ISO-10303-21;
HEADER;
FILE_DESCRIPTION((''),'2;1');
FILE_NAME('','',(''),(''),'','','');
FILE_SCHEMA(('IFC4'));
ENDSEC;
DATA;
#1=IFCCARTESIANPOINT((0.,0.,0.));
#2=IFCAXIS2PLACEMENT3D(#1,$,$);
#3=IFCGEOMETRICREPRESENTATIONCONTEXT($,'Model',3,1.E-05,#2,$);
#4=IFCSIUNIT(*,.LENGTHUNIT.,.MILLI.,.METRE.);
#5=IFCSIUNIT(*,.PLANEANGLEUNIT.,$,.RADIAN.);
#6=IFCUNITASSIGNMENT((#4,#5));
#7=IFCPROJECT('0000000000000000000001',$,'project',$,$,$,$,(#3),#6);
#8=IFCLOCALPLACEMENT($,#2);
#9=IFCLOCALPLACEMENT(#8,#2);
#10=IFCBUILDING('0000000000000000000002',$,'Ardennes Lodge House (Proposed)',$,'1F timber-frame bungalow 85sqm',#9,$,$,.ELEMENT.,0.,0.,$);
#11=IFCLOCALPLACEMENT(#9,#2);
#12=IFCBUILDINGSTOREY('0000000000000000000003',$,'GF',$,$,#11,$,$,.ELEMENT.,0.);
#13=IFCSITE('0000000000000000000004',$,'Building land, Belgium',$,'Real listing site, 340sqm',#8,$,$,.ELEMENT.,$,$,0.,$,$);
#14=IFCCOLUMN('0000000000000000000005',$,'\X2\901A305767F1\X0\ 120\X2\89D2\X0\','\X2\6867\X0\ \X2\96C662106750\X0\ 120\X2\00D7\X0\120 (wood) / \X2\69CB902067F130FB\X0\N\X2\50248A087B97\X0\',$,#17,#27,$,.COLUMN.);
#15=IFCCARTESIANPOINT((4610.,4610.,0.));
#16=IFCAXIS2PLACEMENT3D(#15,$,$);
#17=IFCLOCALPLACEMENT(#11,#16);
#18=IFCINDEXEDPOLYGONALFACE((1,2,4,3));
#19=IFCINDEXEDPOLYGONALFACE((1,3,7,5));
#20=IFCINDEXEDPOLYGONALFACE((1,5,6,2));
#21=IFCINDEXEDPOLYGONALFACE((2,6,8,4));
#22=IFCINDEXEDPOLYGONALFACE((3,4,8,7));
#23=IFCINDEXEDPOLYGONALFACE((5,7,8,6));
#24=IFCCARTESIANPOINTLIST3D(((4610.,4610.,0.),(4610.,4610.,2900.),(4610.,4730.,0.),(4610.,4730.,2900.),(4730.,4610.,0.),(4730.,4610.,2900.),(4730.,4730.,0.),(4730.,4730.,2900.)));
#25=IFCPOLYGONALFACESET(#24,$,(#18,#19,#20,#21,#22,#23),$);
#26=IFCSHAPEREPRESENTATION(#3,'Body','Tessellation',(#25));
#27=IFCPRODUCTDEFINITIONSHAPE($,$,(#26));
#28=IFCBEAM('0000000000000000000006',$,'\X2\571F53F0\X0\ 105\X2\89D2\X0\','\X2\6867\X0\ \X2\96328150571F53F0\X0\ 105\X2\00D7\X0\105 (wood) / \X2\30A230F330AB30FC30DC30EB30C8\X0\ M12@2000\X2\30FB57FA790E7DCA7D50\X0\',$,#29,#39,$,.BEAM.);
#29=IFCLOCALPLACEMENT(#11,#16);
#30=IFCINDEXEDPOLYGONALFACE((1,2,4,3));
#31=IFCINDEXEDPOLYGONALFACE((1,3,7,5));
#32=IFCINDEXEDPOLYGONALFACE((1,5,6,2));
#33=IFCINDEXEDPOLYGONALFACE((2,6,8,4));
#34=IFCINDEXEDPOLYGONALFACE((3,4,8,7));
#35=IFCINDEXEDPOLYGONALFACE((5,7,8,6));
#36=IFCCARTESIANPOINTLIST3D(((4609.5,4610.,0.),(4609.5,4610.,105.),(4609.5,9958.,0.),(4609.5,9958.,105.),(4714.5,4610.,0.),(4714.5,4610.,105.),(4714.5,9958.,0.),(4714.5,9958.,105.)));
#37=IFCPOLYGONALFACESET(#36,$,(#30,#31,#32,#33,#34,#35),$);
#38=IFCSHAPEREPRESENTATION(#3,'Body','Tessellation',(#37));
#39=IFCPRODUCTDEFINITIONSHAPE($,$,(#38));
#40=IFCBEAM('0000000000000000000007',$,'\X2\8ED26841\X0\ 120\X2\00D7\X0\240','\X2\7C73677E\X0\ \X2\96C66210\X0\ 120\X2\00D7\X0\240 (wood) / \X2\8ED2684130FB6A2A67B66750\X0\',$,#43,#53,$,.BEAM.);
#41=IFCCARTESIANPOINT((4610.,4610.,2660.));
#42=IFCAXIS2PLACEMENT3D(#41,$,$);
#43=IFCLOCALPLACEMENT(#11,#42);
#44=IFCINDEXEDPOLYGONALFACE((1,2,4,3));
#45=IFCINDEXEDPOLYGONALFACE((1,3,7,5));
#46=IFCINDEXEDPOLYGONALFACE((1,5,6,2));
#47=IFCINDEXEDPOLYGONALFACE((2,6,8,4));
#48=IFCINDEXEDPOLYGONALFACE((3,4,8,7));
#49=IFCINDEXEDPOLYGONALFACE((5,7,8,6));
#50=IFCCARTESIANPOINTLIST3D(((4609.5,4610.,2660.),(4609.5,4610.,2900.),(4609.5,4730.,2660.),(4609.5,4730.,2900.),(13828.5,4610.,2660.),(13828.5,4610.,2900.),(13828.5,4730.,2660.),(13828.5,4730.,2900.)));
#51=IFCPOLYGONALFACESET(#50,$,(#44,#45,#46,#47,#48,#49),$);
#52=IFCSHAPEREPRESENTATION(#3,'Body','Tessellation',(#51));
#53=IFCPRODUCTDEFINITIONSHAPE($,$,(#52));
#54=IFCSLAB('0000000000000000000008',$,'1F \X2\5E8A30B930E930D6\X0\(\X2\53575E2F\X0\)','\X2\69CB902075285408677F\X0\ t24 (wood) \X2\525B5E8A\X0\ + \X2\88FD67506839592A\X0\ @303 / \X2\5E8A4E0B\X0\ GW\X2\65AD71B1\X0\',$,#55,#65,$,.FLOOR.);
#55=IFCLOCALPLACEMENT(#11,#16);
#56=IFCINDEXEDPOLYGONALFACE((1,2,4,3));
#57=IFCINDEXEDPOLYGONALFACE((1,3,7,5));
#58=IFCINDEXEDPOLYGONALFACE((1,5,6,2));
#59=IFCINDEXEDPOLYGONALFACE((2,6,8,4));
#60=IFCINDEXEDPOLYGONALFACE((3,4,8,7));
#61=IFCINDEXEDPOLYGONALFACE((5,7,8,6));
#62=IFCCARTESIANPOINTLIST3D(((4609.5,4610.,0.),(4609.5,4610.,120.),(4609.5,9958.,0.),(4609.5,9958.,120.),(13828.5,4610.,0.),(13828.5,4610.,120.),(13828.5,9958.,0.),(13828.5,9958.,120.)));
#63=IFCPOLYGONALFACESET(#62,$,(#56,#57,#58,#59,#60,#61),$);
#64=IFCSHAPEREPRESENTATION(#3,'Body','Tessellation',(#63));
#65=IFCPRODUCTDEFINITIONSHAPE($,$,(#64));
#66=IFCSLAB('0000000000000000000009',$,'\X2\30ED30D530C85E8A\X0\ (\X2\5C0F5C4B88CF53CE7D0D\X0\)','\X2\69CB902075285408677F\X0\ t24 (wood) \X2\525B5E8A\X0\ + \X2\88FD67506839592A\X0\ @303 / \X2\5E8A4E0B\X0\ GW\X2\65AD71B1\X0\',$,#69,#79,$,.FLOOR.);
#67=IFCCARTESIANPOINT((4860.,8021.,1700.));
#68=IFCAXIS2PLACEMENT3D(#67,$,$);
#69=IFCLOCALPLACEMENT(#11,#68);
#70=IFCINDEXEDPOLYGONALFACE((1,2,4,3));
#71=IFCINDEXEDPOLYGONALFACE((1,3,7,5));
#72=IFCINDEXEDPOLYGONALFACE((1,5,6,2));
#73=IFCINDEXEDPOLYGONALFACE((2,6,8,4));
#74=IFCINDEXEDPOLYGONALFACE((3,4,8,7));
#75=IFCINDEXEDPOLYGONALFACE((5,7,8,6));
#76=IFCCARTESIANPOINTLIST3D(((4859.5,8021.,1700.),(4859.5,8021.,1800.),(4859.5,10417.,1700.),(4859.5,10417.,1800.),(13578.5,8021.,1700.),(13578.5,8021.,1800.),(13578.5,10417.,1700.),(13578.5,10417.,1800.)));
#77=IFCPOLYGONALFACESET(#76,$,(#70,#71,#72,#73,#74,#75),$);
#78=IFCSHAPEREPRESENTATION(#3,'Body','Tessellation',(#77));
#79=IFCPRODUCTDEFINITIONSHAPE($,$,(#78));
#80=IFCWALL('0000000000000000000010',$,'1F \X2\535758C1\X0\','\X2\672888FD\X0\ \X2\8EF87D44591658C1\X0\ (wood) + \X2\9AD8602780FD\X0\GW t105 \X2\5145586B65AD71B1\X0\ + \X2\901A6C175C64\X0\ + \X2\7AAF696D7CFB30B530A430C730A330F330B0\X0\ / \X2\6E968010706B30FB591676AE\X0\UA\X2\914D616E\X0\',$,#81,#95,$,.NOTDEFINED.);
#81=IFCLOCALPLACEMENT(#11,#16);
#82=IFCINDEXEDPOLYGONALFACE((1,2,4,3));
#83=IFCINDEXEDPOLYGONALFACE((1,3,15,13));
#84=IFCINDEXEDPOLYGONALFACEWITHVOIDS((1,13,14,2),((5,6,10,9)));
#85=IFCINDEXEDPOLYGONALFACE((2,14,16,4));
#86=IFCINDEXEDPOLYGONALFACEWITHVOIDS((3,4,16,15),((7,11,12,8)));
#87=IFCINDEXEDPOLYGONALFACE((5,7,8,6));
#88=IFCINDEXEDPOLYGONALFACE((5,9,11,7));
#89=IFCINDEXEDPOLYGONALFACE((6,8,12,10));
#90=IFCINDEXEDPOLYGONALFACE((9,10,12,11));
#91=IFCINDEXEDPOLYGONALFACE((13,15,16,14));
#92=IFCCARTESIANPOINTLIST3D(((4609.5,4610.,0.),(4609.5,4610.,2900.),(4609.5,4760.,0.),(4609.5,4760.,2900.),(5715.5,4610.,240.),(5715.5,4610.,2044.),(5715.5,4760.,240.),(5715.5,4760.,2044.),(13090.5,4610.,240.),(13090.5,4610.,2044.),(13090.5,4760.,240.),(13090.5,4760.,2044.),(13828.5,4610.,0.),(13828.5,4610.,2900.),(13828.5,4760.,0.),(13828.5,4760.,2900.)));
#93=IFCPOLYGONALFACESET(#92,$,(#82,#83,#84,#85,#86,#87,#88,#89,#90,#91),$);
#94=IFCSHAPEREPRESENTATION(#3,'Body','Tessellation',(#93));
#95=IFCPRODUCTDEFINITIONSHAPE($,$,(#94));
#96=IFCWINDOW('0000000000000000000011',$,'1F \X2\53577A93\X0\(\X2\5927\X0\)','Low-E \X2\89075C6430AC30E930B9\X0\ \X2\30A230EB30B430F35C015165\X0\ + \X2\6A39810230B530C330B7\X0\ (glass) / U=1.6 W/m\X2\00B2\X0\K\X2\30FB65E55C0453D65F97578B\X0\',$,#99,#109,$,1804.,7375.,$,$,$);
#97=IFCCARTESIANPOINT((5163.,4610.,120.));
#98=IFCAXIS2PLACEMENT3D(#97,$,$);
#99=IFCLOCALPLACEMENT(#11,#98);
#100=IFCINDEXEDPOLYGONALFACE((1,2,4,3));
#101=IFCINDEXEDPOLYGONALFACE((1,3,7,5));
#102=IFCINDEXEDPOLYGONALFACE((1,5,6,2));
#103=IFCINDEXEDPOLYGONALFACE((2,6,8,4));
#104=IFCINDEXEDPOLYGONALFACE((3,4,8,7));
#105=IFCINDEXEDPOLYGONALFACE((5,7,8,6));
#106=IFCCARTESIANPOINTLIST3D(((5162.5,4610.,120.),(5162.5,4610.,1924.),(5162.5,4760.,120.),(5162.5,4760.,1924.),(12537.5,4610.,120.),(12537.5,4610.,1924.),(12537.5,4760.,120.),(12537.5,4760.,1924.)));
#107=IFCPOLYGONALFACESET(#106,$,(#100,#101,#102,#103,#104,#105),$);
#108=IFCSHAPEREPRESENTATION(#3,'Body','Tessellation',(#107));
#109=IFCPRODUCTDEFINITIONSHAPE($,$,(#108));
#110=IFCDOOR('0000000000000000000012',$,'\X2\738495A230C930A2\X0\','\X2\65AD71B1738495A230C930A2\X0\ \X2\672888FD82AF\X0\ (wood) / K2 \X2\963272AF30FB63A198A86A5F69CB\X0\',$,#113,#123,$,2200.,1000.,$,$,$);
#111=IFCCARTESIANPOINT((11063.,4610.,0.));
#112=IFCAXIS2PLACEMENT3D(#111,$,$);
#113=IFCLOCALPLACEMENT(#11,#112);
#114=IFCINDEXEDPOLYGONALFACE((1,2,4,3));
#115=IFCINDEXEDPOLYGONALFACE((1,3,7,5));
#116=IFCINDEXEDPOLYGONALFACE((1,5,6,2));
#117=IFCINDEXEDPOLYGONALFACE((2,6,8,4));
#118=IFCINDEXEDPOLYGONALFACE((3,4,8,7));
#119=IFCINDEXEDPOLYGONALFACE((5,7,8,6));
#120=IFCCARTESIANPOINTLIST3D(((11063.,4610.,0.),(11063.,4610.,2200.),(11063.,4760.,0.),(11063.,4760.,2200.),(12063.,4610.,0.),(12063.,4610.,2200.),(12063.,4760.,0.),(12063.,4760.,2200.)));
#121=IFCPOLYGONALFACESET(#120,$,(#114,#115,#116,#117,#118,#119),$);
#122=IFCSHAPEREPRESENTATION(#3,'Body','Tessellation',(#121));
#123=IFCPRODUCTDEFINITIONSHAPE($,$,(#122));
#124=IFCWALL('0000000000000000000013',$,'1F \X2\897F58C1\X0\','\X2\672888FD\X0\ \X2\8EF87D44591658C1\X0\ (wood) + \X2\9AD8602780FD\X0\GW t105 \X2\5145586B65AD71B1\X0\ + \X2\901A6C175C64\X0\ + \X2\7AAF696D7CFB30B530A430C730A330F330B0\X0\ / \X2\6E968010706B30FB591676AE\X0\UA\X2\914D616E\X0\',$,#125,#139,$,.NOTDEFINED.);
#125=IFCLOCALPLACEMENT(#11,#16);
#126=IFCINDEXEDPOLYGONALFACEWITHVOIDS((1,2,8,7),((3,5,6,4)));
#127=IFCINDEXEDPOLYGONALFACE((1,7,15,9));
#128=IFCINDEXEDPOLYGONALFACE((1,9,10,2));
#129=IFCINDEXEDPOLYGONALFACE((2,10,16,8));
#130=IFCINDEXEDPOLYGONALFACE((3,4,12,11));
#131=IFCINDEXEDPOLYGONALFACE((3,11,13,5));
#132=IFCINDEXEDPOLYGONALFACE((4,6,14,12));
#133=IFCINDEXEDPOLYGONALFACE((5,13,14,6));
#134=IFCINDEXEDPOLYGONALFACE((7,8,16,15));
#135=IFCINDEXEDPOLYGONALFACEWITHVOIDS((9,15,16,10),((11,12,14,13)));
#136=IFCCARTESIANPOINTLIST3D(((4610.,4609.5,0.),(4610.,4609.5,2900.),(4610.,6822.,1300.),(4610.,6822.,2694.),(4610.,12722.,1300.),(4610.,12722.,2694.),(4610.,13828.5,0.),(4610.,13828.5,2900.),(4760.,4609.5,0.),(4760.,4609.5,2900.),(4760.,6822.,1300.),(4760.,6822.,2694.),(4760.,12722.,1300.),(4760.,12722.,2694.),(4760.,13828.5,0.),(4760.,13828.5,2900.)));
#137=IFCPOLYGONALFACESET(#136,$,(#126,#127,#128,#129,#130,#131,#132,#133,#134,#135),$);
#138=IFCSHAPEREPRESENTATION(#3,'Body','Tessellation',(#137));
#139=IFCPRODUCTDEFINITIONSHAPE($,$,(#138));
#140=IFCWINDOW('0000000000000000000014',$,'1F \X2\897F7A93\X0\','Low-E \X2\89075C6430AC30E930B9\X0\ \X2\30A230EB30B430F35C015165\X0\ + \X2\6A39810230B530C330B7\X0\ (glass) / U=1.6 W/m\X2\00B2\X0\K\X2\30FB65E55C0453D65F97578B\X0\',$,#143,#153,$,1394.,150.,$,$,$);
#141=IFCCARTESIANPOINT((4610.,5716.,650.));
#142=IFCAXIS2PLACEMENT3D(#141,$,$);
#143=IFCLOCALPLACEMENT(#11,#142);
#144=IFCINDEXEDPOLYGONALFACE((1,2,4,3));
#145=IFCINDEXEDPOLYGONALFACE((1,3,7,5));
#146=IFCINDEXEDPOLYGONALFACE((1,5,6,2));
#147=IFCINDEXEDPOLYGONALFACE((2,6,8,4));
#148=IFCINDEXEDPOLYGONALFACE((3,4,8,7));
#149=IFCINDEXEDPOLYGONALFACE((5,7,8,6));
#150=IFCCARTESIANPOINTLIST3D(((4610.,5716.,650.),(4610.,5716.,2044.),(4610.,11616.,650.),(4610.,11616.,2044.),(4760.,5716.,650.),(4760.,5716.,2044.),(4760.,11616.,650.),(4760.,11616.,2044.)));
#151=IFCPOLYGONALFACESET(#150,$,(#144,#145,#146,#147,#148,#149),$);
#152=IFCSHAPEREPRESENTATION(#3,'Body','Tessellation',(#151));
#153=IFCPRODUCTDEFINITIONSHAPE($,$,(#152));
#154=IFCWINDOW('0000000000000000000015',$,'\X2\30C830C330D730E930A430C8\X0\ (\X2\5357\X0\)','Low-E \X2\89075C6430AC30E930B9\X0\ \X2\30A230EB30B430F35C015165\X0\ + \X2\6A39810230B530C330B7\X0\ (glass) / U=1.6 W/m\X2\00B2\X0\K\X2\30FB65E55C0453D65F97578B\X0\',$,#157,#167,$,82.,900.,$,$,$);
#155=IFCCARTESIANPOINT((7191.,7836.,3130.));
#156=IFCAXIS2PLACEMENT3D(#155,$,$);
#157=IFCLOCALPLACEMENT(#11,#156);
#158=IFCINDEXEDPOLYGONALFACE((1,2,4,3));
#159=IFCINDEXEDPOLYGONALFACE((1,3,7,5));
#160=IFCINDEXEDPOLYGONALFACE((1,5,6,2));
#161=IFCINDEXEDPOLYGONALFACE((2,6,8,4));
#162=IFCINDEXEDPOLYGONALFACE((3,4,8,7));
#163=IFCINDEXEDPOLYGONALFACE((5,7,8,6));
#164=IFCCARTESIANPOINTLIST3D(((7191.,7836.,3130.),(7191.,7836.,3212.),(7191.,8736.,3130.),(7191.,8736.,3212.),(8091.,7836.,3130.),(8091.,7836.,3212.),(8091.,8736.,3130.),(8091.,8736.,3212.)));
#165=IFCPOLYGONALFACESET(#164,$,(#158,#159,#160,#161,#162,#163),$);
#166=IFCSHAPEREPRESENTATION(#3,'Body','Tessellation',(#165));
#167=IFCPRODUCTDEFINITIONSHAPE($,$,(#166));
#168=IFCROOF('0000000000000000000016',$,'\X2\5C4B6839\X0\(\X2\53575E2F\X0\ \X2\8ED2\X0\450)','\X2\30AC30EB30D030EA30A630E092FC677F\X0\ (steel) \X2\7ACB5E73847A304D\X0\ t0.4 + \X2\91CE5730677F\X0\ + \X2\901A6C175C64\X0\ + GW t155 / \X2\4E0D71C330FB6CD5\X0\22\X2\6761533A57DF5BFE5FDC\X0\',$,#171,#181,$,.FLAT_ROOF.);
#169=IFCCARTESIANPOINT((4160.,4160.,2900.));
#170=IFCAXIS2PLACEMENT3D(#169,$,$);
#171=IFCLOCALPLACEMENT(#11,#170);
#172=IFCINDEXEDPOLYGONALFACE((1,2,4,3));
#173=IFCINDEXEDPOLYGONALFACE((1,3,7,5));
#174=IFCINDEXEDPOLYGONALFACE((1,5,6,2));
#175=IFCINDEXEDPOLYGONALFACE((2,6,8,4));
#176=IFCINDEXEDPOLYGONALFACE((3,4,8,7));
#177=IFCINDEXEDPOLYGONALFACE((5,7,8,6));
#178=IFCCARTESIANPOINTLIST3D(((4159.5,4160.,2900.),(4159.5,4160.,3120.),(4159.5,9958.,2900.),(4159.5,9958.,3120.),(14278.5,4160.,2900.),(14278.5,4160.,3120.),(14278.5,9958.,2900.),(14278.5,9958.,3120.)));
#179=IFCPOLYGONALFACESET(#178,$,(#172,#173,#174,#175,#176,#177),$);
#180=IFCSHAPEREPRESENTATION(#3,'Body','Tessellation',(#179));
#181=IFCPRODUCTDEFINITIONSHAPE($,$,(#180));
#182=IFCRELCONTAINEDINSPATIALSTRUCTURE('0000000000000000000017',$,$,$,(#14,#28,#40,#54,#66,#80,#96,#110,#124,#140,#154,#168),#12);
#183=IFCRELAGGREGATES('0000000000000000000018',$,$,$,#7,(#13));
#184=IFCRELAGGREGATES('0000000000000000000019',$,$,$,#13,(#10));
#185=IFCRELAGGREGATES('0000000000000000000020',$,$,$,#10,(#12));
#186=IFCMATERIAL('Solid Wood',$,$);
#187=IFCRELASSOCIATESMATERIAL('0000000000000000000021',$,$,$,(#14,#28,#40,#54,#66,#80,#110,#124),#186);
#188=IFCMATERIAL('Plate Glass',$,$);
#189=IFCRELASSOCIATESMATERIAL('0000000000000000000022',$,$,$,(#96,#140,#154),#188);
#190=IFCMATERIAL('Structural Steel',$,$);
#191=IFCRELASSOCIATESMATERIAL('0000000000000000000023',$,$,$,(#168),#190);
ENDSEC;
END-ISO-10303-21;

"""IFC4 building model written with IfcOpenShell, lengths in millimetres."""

from ifc_helpers import new_model, si_unit, frame, frame_2d, origin, place, context, project, spatial, rectangle, extrude, material, element, fill, save


model = new_model("IFC4")

# Units and contexts
model_context = context("Model", 3, precision=1e-05, world=origin())
ifc_project = project(units=[si_unit("LENGTHUNIT", "METRE", prefix="MILLI"), si_unit("PLANEANGLEUNIT", "RADIAN")], contexts=[model_context])

# Site, building, storey
site_placement = place(None, origin())
site = spatial("IfcSite", under=ifc_project, at=site_placement, Name="Building land, Belgium", ObjectType="Real listing site, 340sqm", CompositionType="ELEMENT", RefElevation=0.0)
building_placement = place(site_placement, origin())
building = spatial("IfcBuilding", under=site, at=building_placement, Name="Ardennes Lodge House (Proposed)", ObjectType="1F timber-frame bungalow 85sqm", CompositionType="ELEMENT", ElevationOfRefHeight=0.0, ElevationOfTerrain=0.0)
storey_placement = place(building_placement, origin())
storey = spatial("IfcBuildingStorey", under=building, at=storey_placement, Name="GF", CompositionType="ELEMENT", Elevation=0.0)

# Column
ifc_material_1 = material(Name="Solid Wood")
column_1_placement = place(storey_placement, frame((4610.0, 4610.0, 0.0)))
element("IfcColumn", 1, at=column_1_placement, inside=storey, material=ifc_material_1, Name="通し柱 120角", Description="桧 集成材 120×120 (wood) / 構造柱・N値計算", PredefinedType="COLUMN", context=model_context, shape_type="SweptSolid", body=[
    extrude(rectangle(XDim=120.0, YDim=120.0, at=frame_2d((60.0, 60.0))), frame((4610.0, 4610.0, 0.0)), (0.0, 0.0, 1.0), 2900.0),
])

# Beams
beam_1_placement = place(storey_placement, frame((4610.0, 4610.0, 0.0)))
element("IfcBeam", 2, at=beam_1_placement, inside=storey, material=ifc_material_1, Name="土台 105角", Description="桧 防腐土台 105×105 (wood) / アンカーボルト M12@2000・基礎緊結", PredefinedType="BEAM", context=model_context, shape_type="SweptSolid", body=[
    extrude(rectangle(XDim=105.0, YDim=5348.0, at=frame_2d((52.0, 2674.0))), frame((4610.0, 4610.0, 0.0)), (0.0, 0.0, 1.0), 105.0),
])
beam_2_placement = place(storey_placement, frame((4610.0, 4610.0, 2660.0)))
element("IfcBeam", 3, at=beam_2_placement, inside=storey, material=ifc_material_1, Name="軒桁 120×240", Description="米松 集成 120×240 (wood) / 軒桁・横架材", PredefinedType="BEAM", context=model_context, shape_type="SweptSolid", body=[
    extrude(rectangle(XDim=9219.0, YDim=120.0, at=frame_2d((4609.0, 60.0))), frame((4610.0, 4610.0, 2660.0)), (0.0, 0.0, 1.0), 240.0),
])

# Slabs
slab_1_placement = place(storey_placement, frame((4610.0, 4610.0, 0.0)))
element("IfcSlab", 4, at=slab_1_placement, inside=storey, material=ifc_material_1, Name="1F 床スラブ(南帯)", Description="構造用合板 t24 (wood) 剛床 + 製材根太 @303 / 床下 GW断熱", PredefinedType="FLOOR", context=model_context, shape_type="SweptSolid", body=[
    extrude(rectangle(XDim=9219.0, YDim=5348.0, at=frame_2d((4609.0, 2674.0))), frame((4610.0, 4610.0, 0.0)), (0.0, 0.0, 1.0), 120.0),
])
slab_2_placement = place(storey_placement, frame((4860.0, 8021.0, 1700.0)))
element("IfcSlab", 5, at=slab_2_placement, inside=storey, material=ifc_material_1, Name="ロフト床 (小屋裏収納)", Description="構造用合板 t24 (wood) 剛床 + 製材根太 @303 / 床下 GW断熱", PredefinedType="FLOOR", context=model_context, shape_type="SweptSolid", body=[
    extrude(rectangle(XDim=8719.0, YDim=2396.0, at=frame_2d((4359.0, 1198.0))), frame((4860.0, 8021.0, 1700.0)), (0.0, 0.0, 1.0), 100.0),
])

# Wall, openings, window, door
wall_1_placement = place(storey_placement, frame((4610.0, 4610.0, 0.0)))
wall_1 = element("IfcWall", 6, at=wall_1_placement, inside=storey, material=ifc_material_1, Name="1F 南壁", Description="木製 軸組外壁 (wood) + 高性能GW t105 充填断熱 + 通気層 + 窯業系サイディング / 準耐火・外皮UA配慮", PredefinedType="NOTDEFINED", context=model_context, shape_type="SweptSolid", body=[
    extrude(rectangle(XDim=9219.0, YDim=150.0, at=frame_2d((4609.0, 75.0))), frame((4610.0, 4610.0, 0.0)), (0.0, 0.0, 1.0), 2900.0),
])
opening_1_placement = place(storey_placement, frame((5163.0, 4610.0, 120.0)))
opening_1 = element("IfcOpeningElement", 7, at=opening_1_placement, cuts=wall_1, PredefinedType="NOTDEFINED", context=model_context, shape_type="SweptSolid", body=[
    extrude(rectangle(XDim=7375.0, YDim=150.0, at=frame_2d((3687.0, 75.0))), frame((5163.0, 4610.0, 120.0)), (0.0, 0.0, 1.0), 1804.0),
])
opening_2_placement = place(storey_placement, frame((11063.0, 4610.0, 0.0)))
opening_2 = element("IfcOpeningElement", 8, at=opening_2_placement, cuts=wall_1, PredefinedType="NOTDEFINED", context=model_context, shape_type="SweptSolid", body=[
    extrude(rectangle(XDim=1000.0, YDim=150.0, at=frame_2d((500.0, 75.0))), frame((11063.0, 4610.0, 0.0)), (0.0, 0.0, 1.0), 2200.0),
])
ifc_material_2 = material(Name="Plate Glass")
window_1_placement = place(storey_placement, frame((5163.0, 4610.0, 120.0)))
window_1 = element("IfcWindow", 9, at=window_1_placement, inside=storey, material=ifc_material_2, Name="1F 南窓(大)", Description="Low-E 複層ガラス アルゴン封入 + 樹脂サッシ (glass) / U=1.6 W/m²K・日射取得型", OverallHeight=1804.0, OverallWidth=7375.0, context=model_context, shape_type="SweptSolid", body=[
    extrude(rectangle(XDim=7375.0, YDim=150.0, at=frame_2d((3687.0, 75.0))), frame((5163.0, 4610.0, 120.0)), (0.0, 0.0, 1.0), 1804.0),
])
fill(opening_1, window_1)
door_1_placement = place(storey_placement, frame((11063.0, 4610.0, 0.0)))
door_1 = element("IfcDoor", 10, at=door_1_placement, inside=storey, material=ifc_material_1, Name="玄関ドア", Description="断熱玄関ドア 木製芯 (wood) / K2 防犯・採風機構", OverallHeight=2200.0, OverallWidth=1000.0, context=model_context, shape_type="SweptSolid", body=[
    extrude(rectangle(XDim=1000.0, YDim=150.0, at=frame_2d((500.0, 75.0))), frame((11063.0, 4610.0, 0.0)), (0.0, 0.0, 1.0), 2200.0),
])
fill(opening_2, door_1)

# Wall, opening, window
wall_2_placement = place(storey_placement, frame((4610.0, 4610.0, 0.0)))
wall_2 = element("IfcWall", 11, at=wall_2_placement, inside=storey, material=ifc_material_1, Name="1F 西壁", Description="木製 軸組外壁 (wood) + 高性能GW t105 充填断熱 + 通気層 + 窯業系サイディング / 準耐火・外皮UA配慮", PredefinedType="NOTDEFINED", context=model_context, shape_type="SweptSolid", body=[
    extrude(rectangle(XDim=150.0, YDim=9219.0, at=frame_2d((75.0, 4609.0))), frame((4610.0, 4610.0, 0.0)), (0.0, 0.0, 1.0), 2900.0),
])
opening_3_placement = place(storey_placement, frame((4610.0, 5716.0, 650.0)))
opening_3 = element("IfcOpeningElement", 12, at=opening_3_placement, cuts=wall_2, PredefinedType="NOTDEFINED", context=model_context, shape_type="SweptSolid", body=[
    extrude(rectangle(XDim=150.0, YDim=5900.0, at=frame_2d((75.0, 2950.0))), frame((4610.0, 5716.0, 650.0)), (0.0, 0.0, 1.0), 1394.0),
])
window_2_placement = place(storey_placement, frame((4610.0, 5716.0, 650.0)))
window_2 = element("IfcWindow", 13, at=window_2_placement, inside=storey, material=ifc_material_2, Name="1F 西窓", Description="Low-E 複層ガラス アルゴン封入 + 樹脂サッシ (glass) / U=1.6 W/m²K・日射取得型", OverallHeight=1394.0, OverallWidth=150.0, context=model_context, shape_type="SweptSolid", body=[
    extrude(rectangle(XDim=150.0, YDim=5900.0, at=frame_2d((75.0, 2950.0))), frame((4610.0, 5716.0, 650.0)), (0.0, 0.0, 1.0), 1394.0),
])
fill(opening_3, window_2)

# Window
window_3_placement = place(storey_placement, frame((7191.0, 7836.0, 3130.0)))
element("IfcWindow", 14, at=window_3_placement, inside=storey, material=ifc_material_2, Name="トップライト (南)", Description="Low-E 複層ガラス アルゴン封入 + 樹脂サッシ (glass) / U=1.6 W/m²K・日射取得型", OverallHeight=82.0, OverallWidth=900.0, context=model_context, shape_type="SweptSolid", body=[
    extrude(rectangle(XDim=900.0, YDim=900.0, at=frame_2d((450.0, 450.0))), frame((7191.0, 7836.0, 3130.0)), (0.0, 0.0, 1.0), 82.0),
])

# Roof
ifc_material_3 = material(Name="Structural Steel")
roof_placement = place(storey_placement, frame((4160.0, 4160.0, 2900.0)))
element("IfcRoof", 15, at=roof_placement, inside=storey, material=ifc_material_3, Name="屋根(南帯 軒450)", Description="ガルバリウム鋼板 (steel) 立平葺き t0.4 + 野地板 + 通気層 + GW t155 / 不燃・法22条区域対応", PredefinedType="FLAT_ROOF", context=model_context, shape_type="SweptSolid", body=[
    extrude(rectangle(XDim=10119.0, YDim=5798.0, at=frame_2d((5059.0, 2899.0))), frame((4160.0, 4160.0, 2900.0)), (0.0, 0.0, 1.0), 220.0),
])

save(model, "model.ifc")
